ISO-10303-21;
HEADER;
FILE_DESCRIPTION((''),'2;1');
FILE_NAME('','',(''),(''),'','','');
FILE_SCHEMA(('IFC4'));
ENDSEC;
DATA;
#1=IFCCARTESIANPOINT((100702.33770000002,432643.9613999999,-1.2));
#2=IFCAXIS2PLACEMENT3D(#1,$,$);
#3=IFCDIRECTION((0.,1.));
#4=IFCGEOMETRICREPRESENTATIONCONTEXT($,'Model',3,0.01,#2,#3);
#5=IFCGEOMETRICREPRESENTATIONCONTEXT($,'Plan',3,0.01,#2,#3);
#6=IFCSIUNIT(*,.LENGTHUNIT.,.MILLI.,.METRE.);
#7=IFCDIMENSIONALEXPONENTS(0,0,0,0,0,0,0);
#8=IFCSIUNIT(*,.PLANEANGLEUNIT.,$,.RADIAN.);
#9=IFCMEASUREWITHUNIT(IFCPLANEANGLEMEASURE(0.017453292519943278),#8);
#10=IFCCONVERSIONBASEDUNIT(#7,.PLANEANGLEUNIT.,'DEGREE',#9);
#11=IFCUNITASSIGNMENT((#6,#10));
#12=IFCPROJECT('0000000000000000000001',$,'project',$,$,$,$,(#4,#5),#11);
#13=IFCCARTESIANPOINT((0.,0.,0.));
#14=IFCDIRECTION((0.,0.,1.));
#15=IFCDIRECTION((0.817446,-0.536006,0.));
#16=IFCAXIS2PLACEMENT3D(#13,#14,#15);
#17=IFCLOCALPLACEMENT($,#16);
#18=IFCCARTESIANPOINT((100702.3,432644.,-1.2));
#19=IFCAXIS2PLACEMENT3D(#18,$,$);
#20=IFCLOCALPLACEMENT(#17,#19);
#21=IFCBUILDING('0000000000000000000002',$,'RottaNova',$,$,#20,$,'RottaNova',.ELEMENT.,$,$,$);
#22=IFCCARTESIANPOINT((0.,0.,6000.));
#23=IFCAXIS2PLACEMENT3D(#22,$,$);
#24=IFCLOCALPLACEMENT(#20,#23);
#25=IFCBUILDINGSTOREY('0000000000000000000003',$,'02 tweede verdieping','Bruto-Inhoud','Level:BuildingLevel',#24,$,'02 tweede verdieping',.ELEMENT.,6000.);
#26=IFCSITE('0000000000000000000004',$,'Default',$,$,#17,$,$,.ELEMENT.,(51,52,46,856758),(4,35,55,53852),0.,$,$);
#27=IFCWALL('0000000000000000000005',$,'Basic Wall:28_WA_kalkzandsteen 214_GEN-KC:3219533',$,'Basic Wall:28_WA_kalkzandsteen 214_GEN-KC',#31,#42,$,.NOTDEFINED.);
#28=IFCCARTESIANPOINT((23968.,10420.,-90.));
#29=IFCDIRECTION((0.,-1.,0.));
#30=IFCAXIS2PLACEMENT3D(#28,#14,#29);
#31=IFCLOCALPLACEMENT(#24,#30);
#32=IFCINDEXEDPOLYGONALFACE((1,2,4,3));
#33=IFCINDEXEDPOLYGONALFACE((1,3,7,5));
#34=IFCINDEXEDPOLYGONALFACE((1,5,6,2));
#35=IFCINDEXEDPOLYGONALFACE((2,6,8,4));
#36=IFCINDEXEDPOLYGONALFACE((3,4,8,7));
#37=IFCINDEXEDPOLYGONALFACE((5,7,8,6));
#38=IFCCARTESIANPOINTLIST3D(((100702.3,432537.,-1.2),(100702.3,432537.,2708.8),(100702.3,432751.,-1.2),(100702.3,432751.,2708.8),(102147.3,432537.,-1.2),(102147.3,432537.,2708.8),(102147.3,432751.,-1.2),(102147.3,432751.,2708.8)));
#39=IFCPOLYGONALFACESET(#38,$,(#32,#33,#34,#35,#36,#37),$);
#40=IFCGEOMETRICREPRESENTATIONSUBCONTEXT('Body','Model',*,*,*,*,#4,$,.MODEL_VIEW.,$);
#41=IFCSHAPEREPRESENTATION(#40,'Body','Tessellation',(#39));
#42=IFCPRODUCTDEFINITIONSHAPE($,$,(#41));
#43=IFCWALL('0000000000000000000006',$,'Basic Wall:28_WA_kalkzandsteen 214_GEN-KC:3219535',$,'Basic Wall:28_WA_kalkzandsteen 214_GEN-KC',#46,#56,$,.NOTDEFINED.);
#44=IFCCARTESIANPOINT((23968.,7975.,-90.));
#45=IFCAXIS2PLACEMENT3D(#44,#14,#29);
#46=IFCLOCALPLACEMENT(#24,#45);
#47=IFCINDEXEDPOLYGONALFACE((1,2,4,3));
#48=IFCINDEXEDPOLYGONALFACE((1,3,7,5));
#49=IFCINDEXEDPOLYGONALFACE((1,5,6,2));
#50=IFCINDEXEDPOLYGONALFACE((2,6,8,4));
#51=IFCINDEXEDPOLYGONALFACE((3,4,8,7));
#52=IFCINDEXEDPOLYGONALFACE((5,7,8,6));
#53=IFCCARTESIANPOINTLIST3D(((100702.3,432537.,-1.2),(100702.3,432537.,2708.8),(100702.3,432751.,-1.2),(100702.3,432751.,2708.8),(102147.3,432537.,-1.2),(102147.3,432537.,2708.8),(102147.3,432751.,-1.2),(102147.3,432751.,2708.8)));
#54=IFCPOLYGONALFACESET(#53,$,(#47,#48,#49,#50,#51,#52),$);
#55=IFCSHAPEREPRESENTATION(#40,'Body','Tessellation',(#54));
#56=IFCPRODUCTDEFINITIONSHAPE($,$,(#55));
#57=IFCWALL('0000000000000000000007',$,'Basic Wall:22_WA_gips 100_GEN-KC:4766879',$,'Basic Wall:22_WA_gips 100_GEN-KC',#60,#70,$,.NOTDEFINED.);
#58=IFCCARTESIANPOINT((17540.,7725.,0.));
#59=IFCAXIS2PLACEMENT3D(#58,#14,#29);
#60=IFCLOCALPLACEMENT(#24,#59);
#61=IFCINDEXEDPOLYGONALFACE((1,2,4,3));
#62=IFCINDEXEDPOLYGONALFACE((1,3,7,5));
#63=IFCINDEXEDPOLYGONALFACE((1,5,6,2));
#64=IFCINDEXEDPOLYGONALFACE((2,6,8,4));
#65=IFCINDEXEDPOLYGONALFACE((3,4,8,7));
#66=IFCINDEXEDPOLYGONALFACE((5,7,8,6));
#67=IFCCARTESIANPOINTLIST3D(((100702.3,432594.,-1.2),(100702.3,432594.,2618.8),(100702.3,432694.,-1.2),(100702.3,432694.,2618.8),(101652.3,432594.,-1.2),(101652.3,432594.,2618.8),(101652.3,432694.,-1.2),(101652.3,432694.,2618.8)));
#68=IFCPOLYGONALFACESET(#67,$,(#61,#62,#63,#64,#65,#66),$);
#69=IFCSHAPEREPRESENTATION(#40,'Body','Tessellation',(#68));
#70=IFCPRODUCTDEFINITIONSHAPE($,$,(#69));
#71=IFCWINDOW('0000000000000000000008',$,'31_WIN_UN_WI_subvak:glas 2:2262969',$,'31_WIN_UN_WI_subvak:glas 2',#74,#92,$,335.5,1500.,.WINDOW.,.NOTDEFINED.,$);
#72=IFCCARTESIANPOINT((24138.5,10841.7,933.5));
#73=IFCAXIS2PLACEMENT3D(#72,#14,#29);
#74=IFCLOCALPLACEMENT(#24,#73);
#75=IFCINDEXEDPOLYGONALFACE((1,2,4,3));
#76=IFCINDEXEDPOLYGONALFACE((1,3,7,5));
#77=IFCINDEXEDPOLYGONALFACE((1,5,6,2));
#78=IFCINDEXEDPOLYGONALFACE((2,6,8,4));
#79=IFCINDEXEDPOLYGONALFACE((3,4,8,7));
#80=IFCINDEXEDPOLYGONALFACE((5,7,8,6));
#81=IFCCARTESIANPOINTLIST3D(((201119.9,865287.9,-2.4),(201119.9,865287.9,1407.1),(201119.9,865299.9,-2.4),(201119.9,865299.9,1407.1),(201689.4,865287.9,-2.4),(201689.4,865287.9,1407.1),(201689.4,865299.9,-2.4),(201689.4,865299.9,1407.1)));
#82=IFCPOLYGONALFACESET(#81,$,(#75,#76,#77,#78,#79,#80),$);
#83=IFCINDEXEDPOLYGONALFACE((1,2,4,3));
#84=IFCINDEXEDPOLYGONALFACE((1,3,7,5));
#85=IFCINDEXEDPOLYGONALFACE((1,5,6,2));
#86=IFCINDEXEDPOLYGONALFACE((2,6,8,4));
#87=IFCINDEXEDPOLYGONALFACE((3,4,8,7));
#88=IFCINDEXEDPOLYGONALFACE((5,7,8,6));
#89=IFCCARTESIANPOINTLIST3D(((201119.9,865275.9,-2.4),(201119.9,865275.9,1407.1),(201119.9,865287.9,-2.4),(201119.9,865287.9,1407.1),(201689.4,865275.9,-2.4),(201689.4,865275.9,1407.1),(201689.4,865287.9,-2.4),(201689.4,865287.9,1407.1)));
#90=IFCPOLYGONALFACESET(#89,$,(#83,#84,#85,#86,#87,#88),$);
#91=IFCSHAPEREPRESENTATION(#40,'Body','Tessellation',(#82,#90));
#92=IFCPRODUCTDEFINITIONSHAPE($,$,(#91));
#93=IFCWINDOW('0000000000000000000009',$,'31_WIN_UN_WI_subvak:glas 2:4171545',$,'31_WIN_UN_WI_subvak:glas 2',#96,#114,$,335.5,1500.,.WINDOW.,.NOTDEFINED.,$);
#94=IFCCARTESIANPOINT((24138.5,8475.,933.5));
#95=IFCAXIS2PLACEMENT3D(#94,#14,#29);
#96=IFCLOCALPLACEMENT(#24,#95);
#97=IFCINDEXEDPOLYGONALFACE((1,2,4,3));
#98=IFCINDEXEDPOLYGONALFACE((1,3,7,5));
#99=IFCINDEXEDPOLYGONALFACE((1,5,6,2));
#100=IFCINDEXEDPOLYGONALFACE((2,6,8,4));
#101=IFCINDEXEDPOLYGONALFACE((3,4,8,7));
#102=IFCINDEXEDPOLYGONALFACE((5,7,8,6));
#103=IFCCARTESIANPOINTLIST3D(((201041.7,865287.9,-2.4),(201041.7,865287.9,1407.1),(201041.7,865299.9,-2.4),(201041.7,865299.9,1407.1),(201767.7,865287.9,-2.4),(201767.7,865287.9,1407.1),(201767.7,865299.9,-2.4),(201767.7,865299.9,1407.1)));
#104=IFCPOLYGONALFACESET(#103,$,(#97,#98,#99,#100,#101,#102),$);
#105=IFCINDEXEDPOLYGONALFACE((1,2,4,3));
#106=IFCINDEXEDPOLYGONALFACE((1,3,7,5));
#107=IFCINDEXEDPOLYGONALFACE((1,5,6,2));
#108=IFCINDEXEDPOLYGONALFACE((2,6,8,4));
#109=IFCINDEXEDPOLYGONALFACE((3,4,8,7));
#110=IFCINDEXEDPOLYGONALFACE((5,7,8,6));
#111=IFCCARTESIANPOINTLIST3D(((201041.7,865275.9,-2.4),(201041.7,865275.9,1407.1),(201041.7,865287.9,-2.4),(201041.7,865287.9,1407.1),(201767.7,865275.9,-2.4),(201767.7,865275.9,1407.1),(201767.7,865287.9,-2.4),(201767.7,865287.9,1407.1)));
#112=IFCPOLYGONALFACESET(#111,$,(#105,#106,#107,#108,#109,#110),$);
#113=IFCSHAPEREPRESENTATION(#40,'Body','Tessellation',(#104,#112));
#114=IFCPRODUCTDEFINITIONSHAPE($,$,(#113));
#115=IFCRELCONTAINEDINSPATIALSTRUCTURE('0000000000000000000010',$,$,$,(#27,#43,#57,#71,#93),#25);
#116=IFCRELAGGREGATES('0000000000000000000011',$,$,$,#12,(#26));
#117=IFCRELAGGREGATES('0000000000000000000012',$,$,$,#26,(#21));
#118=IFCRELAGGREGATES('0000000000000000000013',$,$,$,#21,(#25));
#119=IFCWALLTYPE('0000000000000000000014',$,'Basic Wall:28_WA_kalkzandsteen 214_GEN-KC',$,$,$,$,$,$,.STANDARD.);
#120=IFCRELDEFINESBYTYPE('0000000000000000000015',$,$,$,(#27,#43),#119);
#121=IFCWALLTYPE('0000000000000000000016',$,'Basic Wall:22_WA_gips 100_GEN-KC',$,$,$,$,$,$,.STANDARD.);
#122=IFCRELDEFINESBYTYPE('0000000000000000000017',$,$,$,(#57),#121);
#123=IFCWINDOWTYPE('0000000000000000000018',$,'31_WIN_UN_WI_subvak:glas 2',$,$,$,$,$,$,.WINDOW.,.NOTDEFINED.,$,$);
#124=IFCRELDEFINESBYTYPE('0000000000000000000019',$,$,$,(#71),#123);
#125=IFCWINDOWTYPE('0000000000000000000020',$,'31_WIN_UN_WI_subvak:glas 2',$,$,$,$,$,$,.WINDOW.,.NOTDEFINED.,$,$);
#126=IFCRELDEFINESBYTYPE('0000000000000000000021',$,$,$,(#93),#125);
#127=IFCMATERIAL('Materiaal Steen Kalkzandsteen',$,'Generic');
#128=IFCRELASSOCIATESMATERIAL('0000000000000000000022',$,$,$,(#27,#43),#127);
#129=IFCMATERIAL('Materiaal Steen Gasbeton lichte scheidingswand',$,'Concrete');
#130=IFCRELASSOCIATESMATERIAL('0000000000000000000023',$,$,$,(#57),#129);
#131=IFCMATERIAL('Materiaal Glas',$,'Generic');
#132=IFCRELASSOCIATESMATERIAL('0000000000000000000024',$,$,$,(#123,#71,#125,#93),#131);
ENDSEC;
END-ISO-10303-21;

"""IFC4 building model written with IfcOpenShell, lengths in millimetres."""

from ifc_helpers import new_model, entity, si_unit, converted_unit, direction, frame, place, context, subcontext, project, spatial, indexed_curve, outline, extrude, source, transform, mapped, material, type_object, type_shapes, element, save


model = new_model("IFC4")

# Units and contexts
model_context = context("Model", 3, precision=0.01, world=frame((100702.33770000002, 432643.9613999999, -1.2)), true_north=direction((0.0, 1.0)))
plan_context = context("Plan", 3, precision=0.01, world=frame((100702.33770000002, 432643.9613999999, -1.2)), true_north=direction((0.0, 1.0)))
body_context = subcontext(model_context, "Body", "Model", "MODEL_VIEW")
ifc_project = project(units=[si_unit("LENGTHUNIT", "METRE", prefix="MILLI"), converted_unit("PLANEANGLEUNIT", "DEGREE", entity("IfcPlaneAngleMeasure", 0.017453292519943278), si_unit("PLANEANGLEUNIT", "RADIAN"), dimensions=[0, 0, 0, 0, 0, 0, 0])], contexts=[model_context, plan_context])

# Site, building, storey
site_placement = place(None, frame((0.0, 0.0, 0.0), z_axis=(0.0, 0.0, 1.0), x_axis=(0.817446, -0.536006, 0.0)))
site = spatial("IfcSite", under=ifc_project, at=site_placement, Name="Default", CompositionType="ELEMENT", RefLatitude=(51, 52, 46, 856758), RefLongitude=(4, 35, 55, 53852), RefElevation=0.0)
building_placement = place(site_placement, frame((100702.3, 432644.0, -1.2)))
building = spatial("IfcBuilding", under=site, at=building_placement, Name="RottaNova", LongName="RottaNova", CompositionType="ELEMENT")
storey_placement = place(building_placement, frame((0.0, 0.0, 6000.0)))
storey = spatial("IfcBuildingStorey", under=building, at=storey_placement, Name="02 tweede verdieping", Description="Bruto-Inhoud", ObjectType="Level:BuildingLevel", LongName="02 tweede verdieping", CompositionType="ELEMENT", Elevation=6000.0)

# Shared definitions
ifc_material_1 = material(Name="Materiaal Glas", Category="Generic")

# Walls
ifc_material_2 = material(Name="Materiaal Steen Kalkzandsteen", Category="Generic")
wall_type_1 = type_object("IfcWallType", Name="Basic Wall:28_WA_kalkzandsteen 214_GEN-KC", PredefinedType="STANDARD")
wall_1_placement = place(storey_placement, frame((23968.0, 10420.0, -90.0), z_axis=(0.0, 0.0, 1.0), x_axis=(0.0, -1.0, 0.0)))
element("IfcWall", 1, at=wall_1_placement, inside=storey, type_object=wall_type_1, material=ifc_material_2, Name="Basic Wall:28_WA_kalkzandsteen 214_GEN-KC:3219533", ObjectType="Basic Wall:28_WA_kalkzandsteen 214_GEN-KC", PredefinedType="NOTDEFINED", context=body_context, shape_type="SweptSolid", body=[
    extrude(outline(indexed_curve([(1445.0, 107.0), (0.0, 107.0), (0.0, -107.0), (1445.0, -107.0), (1445.0, 107.0)], self_intersect=False)), frame((100702.3, 432644.0, -1.2)), (0.0, 0.0, 1.0), 2710.0),
])
wall_2_placement = place(storey_placement, frame((23968.0, 7975.0, -90.0), z_axis=(0.0, 0.0, 1.0), x_axis=(0.0, -1.0, 0.0)))
element("IfcWall", 2, at=wall_2_placement, inside=storey, type_object=wall_type_1, material=ifc_material_2, Name="Basic Wall:28_WA_kalkzandsteen 214_GEN-KC:3219535", ObjectType="Basic Wall:28_WA_kalkzandsteen 214_GEN-KC", PredefinedType="NOTDEFINED", context=body_context, shape_type="SweptSolid", body=[
    extrude(outline(indexed_curve([(1445.0, 107.0), (0.0, 107.0), (0.0, -107.0), (1445.0, -107.0), (1445.0, 107.0)], self_intersect=False)), frame((100702.3, 432644.0, -1.2)), (0.0, 0.0, 1.0), 2710.0),
])
ifc_material_3 = material(Name="Materiaal Steen Gasbeton lichte scheidingswand", Category="Concrete")
wall_type_2 = type_object("IfcWallType", Name="Basic Wall:22_WA_gips 100_GEN-KC", PredefinedType="STANDARD")
wall_3_placement = place(storey_placement, frame((17540.0, 7725.0, 0.0), z_axis=(0.0, 0.0, 1.0), x_axis=(0.0, -1.0, 0.0)))
element("IfcWall", 3, at=wall_3_placement, inside=storey, type_object=wall_type_2, material=ifc_material_3, Name="Basic Wall:22_WA_gips 100_GEN-KC:4766879", ObjectType="Basic Wall:22_WA_gips 100_GEN-KC", PredefinedType="NOTDEFINED", context=body_context, shape_type="SweptSolid", body=[
    extrude(outline(indexed_curve([(950.0, 50.0), (0.0, 50.0), (0.0, -50.0), (950.0, -50.0), (950.0, 50.0)], self_intersect=False)), frame((100702.3, 432644.0, -1.2)), (0.0, 0.0, 1.0), 2620.0),
])

# Windows
window_type_1 = type_object("IfcWindowType", Name="31_WIN_UN_WI_subvak:glas 2", PartitioningType="NOTDEFINED", PredefinedType="WINDOW", material=ifc_material_1)
shared_shape_1 = source(frame((100702.3, 432644.0, -1.2)), body_context, "Body", "SweptSolid", [
    extrude(outline(indexed_curve([(-6.0, -284.7), (6.0, -284.7), (6.0, 284.7), (-6.0, 284.7), (-6.0, -284.7)], self_intersect=False)), frame((0.0, 6.0, 0.0), z_axis=(0.0, 0.0, 1.0), x_axis=(0.0, -1.0, 0.0)), (0.0, 0.0, 1.0), 1409.5),
    extrude(outline(indexed_curve([(-6.0, -284.8), (6.0, -284.8), (6.0, 284.8), (-6.0, 284.8), (-6.0, -284.8)], self_intersect=False)), frame((0.0, -6.0, 0.0), z_axis=(0.0, 0.0, 1.0), x_axis=(0.0, -1.0, 0.0)), (0.0, 0.0, 1.0), 1409.5),
])
type_shapes(window_type_1, [shared_shape_1])
window_1_placement = place(storey_placement, frame((24138.5, 10841.7, 933.5), z_axis=(0.0, 0.0, 1.0), x_axis=(0.0, -1.0, 0.0)))
element("IfcWindow", 4, at=window_1_placement, inside=storey, type_object=window_type_1, material=ifc_material_1, Name="31_WIN_UN_WI_subvak:glas 2:2262969", ObjectType="31_WIN_UN_WI_subvak:glas 2", OverallHeight=335.5, OverallWidth=1500.0, PartitioningType="NOTDEFINED", PredefinedType="WINDOW", context=body_context, shape_type="MappedRepresentation", body=[
    mapped(shared_shape_1, transform((100702.3, 432644.0, -1.2), scale=1.0)),
])
window_type_2 = type_object("IfcWindowType", Name="31_WIN_UN_WI_subvak:glas 2", PartitioningType="NOTDEFINED", PredefinedType="WINDOW", material=ifc_material_1)
shared_shape_2 = source(frame((100702.3, 432644.0, -1.2)), body_context, "Body", "SweptSolid", [
    extrude(outline(indexed_curve([(-6.0, -363.0), (6.0, -363.0), (6.0, 363.0), (-6.0, 363.0), (-6.0, -363.0)], self_intersect=False)), frame((0.0, 6.0, 0.0), z_axis=(0.0, 0.0, 1.0), x_axis=(0.0, -1.0, 0.0)), (0.0, 0.0, 1.0), 1409.5),
    extrude(outline(indexed_curve([(-6.0, -363.0), (6.0, -363.0), (6.0, 363.0), (-6.0, 363.0), (-6.0, -363.0)], self_intersect=False)), frame((0.0, -6.0, 0.0), z_axis=(0.0, 0.0, 1.0), x_axis=(0.0, -1.0, 0.0)), (0.0, 0.0, 1.0), 1409.5),
])
type_shapes(window_type_2, [shared_shape_2])
window_2_placement = place(storey_placement, frame((24138.5, 8475.0, 933.5), z_axis=(0.0, 0.0, 1.0), x_axis=(0.0, -1.0, 0.0)))
element("IfcWindow", 5, at=window_2_placement, inside=storey, type_object=window_type_2, material=ifc_material_1, Name="31_WIN_UN_WI_subvak:glas 2:4171545", ObjectType="31_WIN_UN_WI_subvak:glas 2", OverallHeight=335.5, OverallWidth=1500.0, PartitioningType="NOTDEFINED", PredefinedType="WINDOW", context=body_context, shape_type="MappedRepresentation", body=[
    mapped(shared_shape_2, transform((100702.3, 432644.0, -1.2), scale=1.0)),
])

save(model, "model.ifc")
